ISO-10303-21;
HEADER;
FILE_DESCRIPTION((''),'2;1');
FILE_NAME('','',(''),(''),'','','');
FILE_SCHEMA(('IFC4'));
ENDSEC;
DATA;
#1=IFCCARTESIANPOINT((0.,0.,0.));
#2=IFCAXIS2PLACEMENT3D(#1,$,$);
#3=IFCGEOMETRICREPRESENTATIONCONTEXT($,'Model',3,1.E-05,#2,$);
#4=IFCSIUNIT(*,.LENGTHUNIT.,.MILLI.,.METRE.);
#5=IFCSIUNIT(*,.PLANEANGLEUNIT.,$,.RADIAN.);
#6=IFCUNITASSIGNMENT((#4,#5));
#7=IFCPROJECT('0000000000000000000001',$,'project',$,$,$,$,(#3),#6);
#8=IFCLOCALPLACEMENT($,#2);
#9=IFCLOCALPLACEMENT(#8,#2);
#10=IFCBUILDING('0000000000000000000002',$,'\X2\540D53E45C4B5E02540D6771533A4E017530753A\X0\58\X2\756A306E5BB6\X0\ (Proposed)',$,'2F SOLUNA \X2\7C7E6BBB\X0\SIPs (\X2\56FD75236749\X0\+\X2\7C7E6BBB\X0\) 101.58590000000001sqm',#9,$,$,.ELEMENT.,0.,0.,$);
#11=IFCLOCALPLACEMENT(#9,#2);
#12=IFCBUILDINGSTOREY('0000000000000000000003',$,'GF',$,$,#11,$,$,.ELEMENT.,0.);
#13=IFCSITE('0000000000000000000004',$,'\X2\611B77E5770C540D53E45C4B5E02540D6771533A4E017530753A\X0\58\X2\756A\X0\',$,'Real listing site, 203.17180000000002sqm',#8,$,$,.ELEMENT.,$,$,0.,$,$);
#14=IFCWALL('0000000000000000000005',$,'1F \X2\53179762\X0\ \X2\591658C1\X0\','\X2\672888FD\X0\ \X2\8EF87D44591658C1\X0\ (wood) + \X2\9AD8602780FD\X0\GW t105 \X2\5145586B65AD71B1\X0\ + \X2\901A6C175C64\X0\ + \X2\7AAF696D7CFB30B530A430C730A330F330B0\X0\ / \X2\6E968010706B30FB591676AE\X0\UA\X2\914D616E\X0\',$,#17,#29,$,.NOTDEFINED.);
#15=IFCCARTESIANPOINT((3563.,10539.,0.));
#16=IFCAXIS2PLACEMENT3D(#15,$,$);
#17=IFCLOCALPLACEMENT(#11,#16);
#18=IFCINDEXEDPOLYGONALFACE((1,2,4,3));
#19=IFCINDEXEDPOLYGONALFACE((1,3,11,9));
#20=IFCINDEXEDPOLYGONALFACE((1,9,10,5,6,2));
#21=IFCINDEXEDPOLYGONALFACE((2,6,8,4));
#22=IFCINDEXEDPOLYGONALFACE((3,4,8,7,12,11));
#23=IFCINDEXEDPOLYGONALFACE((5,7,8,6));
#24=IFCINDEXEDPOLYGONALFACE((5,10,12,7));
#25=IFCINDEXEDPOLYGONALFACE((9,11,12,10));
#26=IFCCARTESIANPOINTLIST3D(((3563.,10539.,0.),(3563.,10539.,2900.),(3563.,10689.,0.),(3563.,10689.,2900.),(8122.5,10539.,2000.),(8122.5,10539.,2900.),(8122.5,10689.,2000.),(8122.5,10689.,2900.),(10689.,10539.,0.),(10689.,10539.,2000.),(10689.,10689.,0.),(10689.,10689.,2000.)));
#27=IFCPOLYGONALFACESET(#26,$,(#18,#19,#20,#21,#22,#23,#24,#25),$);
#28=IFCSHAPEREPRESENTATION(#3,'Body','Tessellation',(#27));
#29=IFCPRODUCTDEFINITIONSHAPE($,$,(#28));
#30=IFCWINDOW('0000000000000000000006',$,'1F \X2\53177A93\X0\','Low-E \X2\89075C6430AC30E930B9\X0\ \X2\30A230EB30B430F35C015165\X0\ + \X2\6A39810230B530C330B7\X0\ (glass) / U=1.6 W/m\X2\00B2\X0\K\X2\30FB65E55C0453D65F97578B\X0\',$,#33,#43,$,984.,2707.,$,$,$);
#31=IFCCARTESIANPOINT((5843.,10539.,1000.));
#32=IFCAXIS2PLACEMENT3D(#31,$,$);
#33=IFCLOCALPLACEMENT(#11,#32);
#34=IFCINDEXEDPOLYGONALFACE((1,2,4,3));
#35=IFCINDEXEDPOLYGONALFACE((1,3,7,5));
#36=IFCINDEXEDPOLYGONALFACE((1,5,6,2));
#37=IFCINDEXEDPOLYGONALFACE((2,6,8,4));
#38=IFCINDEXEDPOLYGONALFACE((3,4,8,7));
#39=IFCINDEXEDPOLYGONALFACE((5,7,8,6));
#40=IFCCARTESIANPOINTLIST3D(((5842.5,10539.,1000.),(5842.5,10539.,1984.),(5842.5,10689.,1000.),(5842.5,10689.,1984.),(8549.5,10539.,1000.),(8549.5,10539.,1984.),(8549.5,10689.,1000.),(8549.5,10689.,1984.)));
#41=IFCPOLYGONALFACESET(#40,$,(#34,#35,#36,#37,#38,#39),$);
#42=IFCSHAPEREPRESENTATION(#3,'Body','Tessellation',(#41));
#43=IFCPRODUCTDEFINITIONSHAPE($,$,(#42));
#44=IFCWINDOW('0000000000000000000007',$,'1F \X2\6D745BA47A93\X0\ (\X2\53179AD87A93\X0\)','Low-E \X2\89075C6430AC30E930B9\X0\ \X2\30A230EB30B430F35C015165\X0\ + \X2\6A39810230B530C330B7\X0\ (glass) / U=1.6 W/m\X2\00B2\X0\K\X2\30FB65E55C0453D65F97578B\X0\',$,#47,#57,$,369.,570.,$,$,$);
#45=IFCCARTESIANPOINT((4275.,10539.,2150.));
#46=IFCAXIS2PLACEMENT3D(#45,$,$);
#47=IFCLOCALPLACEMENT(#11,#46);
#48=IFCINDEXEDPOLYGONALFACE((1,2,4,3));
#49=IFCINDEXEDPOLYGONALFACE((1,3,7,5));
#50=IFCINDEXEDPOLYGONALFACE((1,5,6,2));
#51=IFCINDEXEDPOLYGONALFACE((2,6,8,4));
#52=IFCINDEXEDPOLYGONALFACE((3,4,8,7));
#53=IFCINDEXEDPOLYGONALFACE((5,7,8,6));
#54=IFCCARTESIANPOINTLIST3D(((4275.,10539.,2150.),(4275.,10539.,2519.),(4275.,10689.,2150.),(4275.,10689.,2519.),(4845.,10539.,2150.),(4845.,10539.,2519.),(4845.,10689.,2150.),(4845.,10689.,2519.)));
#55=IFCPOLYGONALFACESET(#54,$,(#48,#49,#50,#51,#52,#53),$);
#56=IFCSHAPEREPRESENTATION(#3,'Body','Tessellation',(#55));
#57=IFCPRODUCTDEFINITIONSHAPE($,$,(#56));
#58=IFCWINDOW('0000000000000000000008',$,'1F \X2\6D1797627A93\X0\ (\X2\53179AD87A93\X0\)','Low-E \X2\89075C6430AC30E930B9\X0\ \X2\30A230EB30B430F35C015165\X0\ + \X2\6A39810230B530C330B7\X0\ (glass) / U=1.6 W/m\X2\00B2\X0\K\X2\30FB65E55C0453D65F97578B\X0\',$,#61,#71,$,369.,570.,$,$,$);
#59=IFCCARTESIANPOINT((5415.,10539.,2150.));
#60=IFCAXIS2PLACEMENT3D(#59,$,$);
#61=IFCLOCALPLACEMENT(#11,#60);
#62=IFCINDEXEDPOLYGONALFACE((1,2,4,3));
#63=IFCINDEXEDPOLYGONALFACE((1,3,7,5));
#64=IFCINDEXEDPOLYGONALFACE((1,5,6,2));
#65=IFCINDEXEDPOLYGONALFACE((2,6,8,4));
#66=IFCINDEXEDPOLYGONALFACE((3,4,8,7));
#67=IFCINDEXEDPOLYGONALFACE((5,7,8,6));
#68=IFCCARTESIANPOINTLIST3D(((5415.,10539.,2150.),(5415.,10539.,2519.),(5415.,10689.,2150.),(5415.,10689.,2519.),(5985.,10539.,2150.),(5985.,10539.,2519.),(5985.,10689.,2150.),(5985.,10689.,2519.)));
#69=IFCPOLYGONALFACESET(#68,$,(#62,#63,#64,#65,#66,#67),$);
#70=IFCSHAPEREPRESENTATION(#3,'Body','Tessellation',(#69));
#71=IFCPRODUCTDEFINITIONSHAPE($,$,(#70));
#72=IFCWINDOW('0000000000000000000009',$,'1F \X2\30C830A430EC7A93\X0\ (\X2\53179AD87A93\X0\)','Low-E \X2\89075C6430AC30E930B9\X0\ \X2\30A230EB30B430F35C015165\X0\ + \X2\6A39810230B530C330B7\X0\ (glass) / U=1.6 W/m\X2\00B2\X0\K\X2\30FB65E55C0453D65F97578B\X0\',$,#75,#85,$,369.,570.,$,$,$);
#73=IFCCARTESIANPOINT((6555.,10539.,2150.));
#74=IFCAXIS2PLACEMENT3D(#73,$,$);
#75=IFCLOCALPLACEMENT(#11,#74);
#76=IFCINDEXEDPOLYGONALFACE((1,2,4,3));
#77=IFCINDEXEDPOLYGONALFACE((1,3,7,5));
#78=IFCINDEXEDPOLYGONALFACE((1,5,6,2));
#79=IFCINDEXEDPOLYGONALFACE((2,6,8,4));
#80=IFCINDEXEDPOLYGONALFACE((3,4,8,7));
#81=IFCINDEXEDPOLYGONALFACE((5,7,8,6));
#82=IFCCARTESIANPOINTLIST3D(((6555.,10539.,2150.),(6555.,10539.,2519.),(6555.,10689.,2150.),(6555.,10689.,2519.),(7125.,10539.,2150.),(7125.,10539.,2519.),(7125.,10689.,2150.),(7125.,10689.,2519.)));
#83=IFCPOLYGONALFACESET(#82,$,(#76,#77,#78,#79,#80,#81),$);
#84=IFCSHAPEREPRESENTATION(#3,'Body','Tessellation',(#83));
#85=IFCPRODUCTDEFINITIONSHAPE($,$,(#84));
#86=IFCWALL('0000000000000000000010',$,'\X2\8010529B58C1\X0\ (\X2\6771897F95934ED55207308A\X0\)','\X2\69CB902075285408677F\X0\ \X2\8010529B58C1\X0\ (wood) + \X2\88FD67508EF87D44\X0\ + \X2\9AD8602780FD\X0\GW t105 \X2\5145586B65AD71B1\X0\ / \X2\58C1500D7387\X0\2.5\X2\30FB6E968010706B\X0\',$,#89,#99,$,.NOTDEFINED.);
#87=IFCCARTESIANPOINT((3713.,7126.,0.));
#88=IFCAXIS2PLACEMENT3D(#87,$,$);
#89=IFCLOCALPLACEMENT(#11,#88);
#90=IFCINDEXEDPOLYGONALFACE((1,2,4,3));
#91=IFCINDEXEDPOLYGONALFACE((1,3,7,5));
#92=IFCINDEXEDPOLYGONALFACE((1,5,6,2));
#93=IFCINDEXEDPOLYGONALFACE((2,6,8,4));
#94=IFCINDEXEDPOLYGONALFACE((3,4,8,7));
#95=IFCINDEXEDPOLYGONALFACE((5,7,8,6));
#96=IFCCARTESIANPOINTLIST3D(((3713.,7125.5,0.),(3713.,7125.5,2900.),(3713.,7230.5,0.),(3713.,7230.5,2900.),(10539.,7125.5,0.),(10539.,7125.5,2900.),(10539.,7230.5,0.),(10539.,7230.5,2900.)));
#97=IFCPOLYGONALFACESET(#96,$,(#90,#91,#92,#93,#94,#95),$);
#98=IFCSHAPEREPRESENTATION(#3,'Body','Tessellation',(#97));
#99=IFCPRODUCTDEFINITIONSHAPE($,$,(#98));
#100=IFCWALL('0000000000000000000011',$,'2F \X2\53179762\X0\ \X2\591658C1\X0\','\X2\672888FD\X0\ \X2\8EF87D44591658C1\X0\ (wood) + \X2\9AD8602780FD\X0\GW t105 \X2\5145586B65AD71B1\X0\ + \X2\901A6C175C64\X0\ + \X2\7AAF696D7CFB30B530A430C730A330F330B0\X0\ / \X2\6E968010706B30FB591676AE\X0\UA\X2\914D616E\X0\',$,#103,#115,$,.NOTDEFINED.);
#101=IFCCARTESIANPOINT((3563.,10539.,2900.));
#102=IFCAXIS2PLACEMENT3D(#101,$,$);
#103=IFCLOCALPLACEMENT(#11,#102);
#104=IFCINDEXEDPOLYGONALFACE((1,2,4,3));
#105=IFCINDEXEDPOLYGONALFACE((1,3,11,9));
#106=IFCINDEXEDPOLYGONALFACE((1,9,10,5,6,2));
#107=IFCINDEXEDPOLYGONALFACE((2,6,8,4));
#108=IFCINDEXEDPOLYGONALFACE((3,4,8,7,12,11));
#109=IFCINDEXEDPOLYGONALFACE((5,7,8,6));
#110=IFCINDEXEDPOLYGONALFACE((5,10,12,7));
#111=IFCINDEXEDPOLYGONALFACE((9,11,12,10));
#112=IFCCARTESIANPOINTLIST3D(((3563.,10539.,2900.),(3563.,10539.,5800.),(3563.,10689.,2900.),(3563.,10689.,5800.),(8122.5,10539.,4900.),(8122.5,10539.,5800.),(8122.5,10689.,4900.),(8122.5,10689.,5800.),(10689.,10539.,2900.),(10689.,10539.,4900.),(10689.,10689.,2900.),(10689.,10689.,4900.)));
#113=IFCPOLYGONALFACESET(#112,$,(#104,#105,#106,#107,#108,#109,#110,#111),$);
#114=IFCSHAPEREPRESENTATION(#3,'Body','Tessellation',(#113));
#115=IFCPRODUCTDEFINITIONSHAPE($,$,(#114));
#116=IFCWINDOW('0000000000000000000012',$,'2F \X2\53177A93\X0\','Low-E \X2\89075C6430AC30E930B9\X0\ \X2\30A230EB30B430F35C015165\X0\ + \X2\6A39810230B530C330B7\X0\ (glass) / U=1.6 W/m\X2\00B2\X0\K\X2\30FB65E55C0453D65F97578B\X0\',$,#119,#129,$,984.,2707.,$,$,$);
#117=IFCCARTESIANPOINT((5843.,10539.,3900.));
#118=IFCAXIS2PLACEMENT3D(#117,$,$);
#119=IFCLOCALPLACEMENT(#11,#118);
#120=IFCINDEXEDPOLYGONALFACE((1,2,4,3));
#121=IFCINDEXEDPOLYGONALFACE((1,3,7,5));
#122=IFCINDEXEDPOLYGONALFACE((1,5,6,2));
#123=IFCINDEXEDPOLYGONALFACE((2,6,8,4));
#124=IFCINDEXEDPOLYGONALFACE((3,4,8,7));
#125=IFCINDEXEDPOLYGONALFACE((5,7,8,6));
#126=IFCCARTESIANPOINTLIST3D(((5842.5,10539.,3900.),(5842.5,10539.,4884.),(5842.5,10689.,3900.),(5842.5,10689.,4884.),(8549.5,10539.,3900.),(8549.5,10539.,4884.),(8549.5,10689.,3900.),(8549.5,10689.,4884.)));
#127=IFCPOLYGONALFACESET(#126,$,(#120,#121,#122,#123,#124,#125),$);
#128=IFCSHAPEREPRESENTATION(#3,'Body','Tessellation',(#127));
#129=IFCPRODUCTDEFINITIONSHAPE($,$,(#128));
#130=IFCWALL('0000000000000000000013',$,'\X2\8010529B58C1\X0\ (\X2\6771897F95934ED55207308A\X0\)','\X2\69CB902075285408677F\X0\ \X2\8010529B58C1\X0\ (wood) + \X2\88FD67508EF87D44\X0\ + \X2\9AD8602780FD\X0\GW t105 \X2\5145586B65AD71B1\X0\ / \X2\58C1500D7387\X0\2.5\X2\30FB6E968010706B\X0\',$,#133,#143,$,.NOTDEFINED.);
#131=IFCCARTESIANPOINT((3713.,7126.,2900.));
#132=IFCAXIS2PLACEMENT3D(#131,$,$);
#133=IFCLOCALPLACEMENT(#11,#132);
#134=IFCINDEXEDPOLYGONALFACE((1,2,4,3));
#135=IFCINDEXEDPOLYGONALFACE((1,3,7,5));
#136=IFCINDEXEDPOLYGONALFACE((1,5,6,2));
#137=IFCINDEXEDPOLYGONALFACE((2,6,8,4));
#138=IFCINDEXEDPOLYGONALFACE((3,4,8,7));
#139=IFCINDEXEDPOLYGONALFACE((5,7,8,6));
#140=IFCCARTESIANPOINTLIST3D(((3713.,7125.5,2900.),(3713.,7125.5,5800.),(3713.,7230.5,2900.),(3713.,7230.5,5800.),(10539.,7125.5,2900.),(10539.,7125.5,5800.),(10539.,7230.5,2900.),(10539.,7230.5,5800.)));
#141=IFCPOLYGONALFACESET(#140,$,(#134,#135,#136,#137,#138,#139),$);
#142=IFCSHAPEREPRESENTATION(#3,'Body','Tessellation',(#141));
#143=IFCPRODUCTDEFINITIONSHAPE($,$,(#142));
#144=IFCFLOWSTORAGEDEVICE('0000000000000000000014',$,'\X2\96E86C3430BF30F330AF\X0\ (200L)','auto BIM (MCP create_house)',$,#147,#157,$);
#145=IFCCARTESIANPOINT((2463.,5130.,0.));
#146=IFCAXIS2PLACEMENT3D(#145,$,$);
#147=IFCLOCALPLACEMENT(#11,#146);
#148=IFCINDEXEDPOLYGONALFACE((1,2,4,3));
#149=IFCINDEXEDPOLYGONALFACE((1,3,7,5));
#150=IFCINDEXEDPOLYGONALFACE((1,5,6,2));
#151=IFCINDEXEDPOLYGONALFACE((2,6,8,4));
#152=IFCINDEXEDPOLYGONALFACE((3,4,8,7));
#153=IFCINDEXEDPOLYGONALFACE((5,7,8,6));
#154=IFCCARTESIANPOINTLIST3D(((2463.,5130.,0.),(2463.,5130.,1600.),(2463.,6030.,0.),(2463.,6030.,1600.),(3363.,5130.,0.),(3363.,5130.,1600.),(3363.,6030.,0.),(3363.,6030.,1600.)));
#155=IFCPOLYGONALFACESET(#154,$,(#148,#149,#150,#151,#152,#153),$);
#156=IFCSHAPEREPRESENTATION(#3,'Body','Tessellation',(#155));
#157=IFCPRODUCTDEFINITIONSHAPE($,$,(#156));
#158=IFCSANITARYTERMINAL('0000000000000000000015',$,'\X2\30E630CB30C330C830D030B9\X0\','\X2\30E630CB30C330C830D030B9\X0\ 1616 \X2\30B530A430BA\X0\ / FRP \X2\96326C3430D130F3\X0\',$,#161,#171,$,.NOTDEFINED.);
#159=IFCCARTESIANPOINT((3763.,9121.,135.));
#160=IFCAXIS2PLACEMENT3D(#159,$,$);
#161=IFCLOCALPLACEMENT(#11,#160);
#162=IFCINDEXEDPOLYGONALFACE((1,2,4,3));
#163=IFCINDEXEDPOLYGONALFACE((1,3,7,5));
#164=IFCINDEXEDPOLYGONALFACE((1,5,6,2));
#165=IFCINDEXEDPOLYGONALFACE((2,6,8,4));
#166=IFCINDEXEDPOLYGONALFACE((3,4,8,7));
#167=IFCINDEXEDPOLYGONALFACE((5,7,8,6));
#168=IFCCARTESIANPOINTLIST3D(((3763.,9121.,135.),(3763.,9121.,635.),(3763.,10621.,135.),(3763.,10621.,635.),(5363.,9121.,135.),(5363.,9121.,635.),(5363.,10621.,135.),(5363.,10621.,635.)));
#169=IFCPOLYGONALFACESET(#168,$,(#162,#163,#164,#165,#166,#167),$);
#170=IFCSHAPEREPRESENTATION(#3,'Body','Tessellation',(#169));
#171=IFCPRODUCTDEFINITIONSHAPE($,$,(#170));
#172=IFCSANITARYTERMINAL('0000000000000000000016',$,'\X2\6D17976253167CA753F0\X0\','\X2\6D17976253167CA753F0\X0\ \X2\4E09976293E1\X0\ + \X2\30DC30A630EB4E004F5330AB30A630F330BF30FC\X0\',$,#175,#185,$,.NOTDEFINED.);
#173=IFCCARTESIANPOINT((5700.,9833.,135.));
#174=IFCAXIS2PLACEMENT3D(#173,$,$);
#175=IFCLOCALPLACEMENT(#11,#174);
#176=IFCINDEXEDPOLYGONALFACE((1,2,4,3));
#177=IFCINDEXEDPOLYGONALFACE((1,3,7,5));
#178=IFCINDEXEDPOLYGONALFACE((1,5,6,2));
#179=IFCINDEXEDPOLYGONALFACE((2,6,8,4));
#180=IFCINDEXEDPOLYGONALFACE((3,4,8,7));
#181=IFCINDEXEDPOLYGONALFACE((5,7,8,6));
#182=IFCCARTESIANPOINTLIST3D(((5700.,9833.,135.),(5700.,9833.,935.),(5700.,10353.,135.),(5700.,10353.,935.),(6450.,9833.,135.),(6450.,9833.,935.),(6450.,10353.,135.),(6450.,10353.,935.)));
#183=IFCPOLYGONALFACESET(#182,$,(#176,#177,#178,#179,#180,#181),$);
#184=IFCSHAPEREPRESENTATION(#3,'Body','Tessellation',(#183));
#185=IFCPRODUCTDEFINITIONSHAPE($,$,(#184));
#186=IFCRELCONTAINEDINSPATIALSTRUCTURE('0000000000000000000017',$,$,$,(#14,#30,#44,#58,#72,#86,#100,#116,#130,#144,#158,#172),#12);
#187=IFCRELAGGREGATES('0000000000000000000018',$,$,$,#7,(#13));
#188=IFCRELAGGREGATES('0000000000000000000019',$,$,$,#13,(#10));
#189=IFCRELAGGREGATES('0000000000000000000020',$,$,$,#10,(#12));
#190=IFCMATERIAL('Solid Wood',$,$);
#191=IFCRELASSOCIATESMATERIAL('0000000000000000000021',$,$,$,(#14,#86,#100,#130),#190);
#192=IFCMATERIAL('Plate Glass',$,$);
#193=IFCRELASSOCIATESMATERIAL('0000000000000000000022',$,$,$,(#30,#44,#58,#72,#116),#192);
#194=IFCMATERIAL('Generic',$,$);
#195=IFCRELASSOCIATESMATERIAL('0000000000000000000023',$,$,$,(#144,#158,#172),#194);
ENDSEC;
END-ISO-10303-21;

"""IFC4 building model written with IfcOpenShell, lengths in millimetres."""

from ifc_helpers import new_model, si_unit, frame, frame_2d, origin, place, context, project, spatial, rectangle, extrude, material, element, fill, save


model = new_model("IFC4")

# Units and contexts
model_context = context("Model", 3, precision=1e-05, world=origin())
ifc_project = project(units=[si_unit("LENGTHUNIT", "METRE", prefix="MILLI"), si_unit("PLANEANGLEUNIT", "RADIAN")], contexts=[model_context])

# Site, building, storey
site_placement = place(None, origin())
site = spatial("IfcSite", under=ifc_project, at=site_placement, Name="愛知県名古屋市名東区丁田町58番", ObjectType="Real listing site, 203.17180000000002sqm", CompositionType="ELEMENT", RefElevation=0.0)
building_placement = place(site_placement, origin())
building = spatial("IfcBuilding", under=site, at=building_placement, Name="名古屋市名東区丁田町58番の家 (Proposed)", ObjectType="2F SOLUNA 籾殻SIPs (国産杉+籾殻) 101.58590000000001sqm", CompositionType="ELEMENT", ElevationOfRefHeight=0.0, ElevationOfTerrain=0.0)
storey_placement = place(building_placement, origin())
storey = spatial("IfcBuildingStorey", under=building, at=storey_placement, Name="GF", CompositionType="ELEMENT", Elevation=0.0)

# Wall, openings, windows
ifc_material_1 = material(Name="Solid Wood")
wall_1_placement = place(storey_placement, frame((3563.0, 10539.0, 0.0)))
wall_1 = element("IfcWall", 1, at=wall_1_placement, inside=storey, material=ifc_material_1, Name="1F 北面 外壁", Description="木製 軸組外壁 (wood) + 高性能GW t105 充填断熱 + 通気層 + 窯業系サイディング / 準耐火・外皮UA配慮", PredefinedType="NOTDEFINED", context=model_context, shape_type="SweptSolid", body=[
    extrude(rectangle(XDim=7126.0, YDim=150.0, at=frame_2d((3563.0, 75.0))), frame((3563.0, 10539.0, 0.0)), (0.0, 0.0, 1.0), 2900.0),
])
opening_1_placement = place(storey_placement, frame((5843.0, 10539.0, 1000.0)))
opening_1 = element("IfcOpeningElement", 2, at=opening_1_placement, cuts=wall_1, PredefinedType="NOTDEFINED", context=model_context, shape_type="SweptSolid", body=[
    extrude(rectangle(XDim=2707.0, YDim=150.0, at=frame_2d((1353.0, 75.0))), frame((5843.0, 10539.0, 1000.0)), (0.0, 0.0, 1.0), 984.0),
])
opening_2_placement = place(storey_placement, frame((4275.0, 10539.0, 2150.0)))
opening_2 = element("IfcOpeningElement", 3, at=opening_2_placement, cuts=wall_1, PredefinedType="NOTDEFINED", context=model_context, shape_type="SweptSolid", body=[
    extrude(rectangle(XDim=570.0, YDim=150.0, at=frame_2d((285.0, 75.0))), frame((4275.0, 10539.0, 2150.0)), (0.0, 0.0, 1.0), 369.0),
])
opening_3_placement = place(storey_placement, frame((5415.0, 10539.0, 2150.0)))
opening_3 = element("IfcOpeningElement", 4, at=opening_3_placement, cuts=wall_1, PredefinedType="NOTDEFINED", context=model_context, shape_type="SweptSolid", body=[
    extrude(rectangle(XDim=570.0, YDim=150.0, at=frame_2d((285.0, 75.0))), frame((5415.0, 10539.0, 2150.0)), (0.0, 0.0, 1.0), 369.0),
])
opening_4_placement = place(storey_placement, frame((6555.0, 10539.0, 2150.0)))
opening_4 = element("IfcOpeningElement", 5, at=opening_4_placement, cuts=wall_1, PredefinedType="NOTDEFINED", context=model_context, shape_type="SweptSolid", body=[
    extrude(rectangle(XDim=570.0, YDim=150.0, at=frame_2d((285.0, 75.0))), frame((6555.0, 10539.0, 2150.0)), (0.0, 0.0, 1.0), 369.0),
])
ifc_material_2 = material(Name="Plate Glass")
window_1_placement = place(storey_placement, frame((5843.0, 10539.0, 1000.0)))
window_1 = element("IfcWindow", 6, at=window_1_placement, inside=storey, material=ifc_material_2, Name="1F 北窓", Description="Low-E 複層ガラス アルゴン封入 + 樹脂サッシ (glass) / U=1.6 W/m²K・日射取得型", OverallHeight=984.0, OverallWidth=2707.0, context=model_context, shape_type="SweptSolid", body=[
    extrude(rectangle(XDim=2707.0, YDim=150.0, at=frame_2d((1353.0, 75.0))), frame((5843.0, 10539.0, 1000.0)), (0.0, 0.0, 1.0), 984.0),
])
fill(opening_1, window_1)
window_2_placement = place(storey_placement, frame((4275.0, 10539.0, 2150.0)))
window_2 = element("IfcWindow", 7, at=window_2_placement, inside=storey, material=ifc_material_2, Name="1F 浴室窓 (北高窓)", Description="Low-E 複層ガラス アルゴン封入 + 樹脂サッシ (glass) / U=1.6 W/m²K・日射取得型", OverallHeight=369.0, OverallWidth=570.0, context=model_context, shape_type="SweptSolid", body=[
    extrude(rectangle(XDim=570.0, YDim=150.0, at=frame_2d((285.0, 75.0))), frame((4275.0, 10539.0, 2150.0)), (0.0, 0.0, 1.0), 369.0),
])
fill(opening_2, window_2)
window_3_placement = place(storey_placement, frame((5415.0, 10539.0, 2150.0)))
window_3 = element("IfcWindow", 8, at=window_3_placement, inside=storey, material=ifc_material_2, Name="1F 洗面窓 (北高窓)", Description="Low-E 複層ガラス アルゴン封入 + 樹脂サッシ (glass) / U=1.6 W/m²K・日射取得型", OverallHeight=369.0, OverallWidth=570.0, context=model_context, shape_type="SweptSolid", body=[
    extrude(rectangle(XDim=570.0, YDim=150.0, at=frame_2d((285.0, 75.0))), frame((5415.0, 10539.0, 2150.0)), (0.0, 0.0, 1.0), 369.0),
])
fill(opening_3, window_3)
window_4_placement = place(storey_placement, frame((6555.0, 10539.0, 2150.0)))
window_4 = element("IfcWindow", 9, at=window_4_placement, inside=storey, material=ifc_material_2, Name="1F トイレ窓 (北高窓)", Description="Low-E 複層ガラス アルゴン封入 + 樹脂サッシ (glass) / U=1.6 W/m²K・日射取得型", OverallHeight=369.0, OverallWidth=570.0, context=model_context, shape_type="SweptSolid", body=[
    extrude(rectangle(XDim=570.0, YDim=150.0, at=frame_2d((285.0, 75.0))), frame((6555.0, 10539.0, 2150.0)), (0.0, 0.0, 1.0), 369.0),
])
fill(opening_4, window_4)

# Wall
wall_2_placement = place(storey_placement, frame((3713.0, 7126.0, 0.0)))
element("IfcWall", 10, at=wall_2_placement, inside=storey, material=ifc_material_1, Name="耐力壁 (東西間仕切り)", Description="構造用合板 耐力壁 (wood) + 製材軸組 + 高性能GW t105 充填断熱 / 壁倍率2.5・準耐火", PredefinedType="NOTDEFINED", context=model_context, shape_type="SweptSolid", body=[
    extrude(rectangle(XDim=6826.0, YDim=105.0, at=frame_2d((3413.0, 52.0))), frame((3713.0, 7126.0, 0.0)), (0.0, 0.0, 1.0), 2900.0),
])

# Wall, opening, window
wall_3_placement = place(storey_placement, frame((3563.0, 10539.0, 2900.0)))
wall_3 = element("IfcWall", 11, at=wall_3_placement, inside=storey, material=ifc_material_1, Name="2F 北面 外壁", Description="木製 軸組外壁 (wood) + 高性能GW t105 充填断熱 + 通気層 + 窯業系サイディング / 準耐火・外皮UA配慮", PredefinedType="NOTDEFINED", context=model_context, shape_type="SweptSolid", body=[
    extrude(rectangle(XDim=7126.0, YDim=150.0, at=frame_2d((3563.0, 75.0))), frame((3563.0, 10539.0, 2900.0)), (0.0, 0.0, 1.0), 2900.0),
])
opening_5_placement = place(storey_placement, frame((5843.0, 10539.0, 3900.0)))
opening_5 = element("IfcOpeningElement", 12, at=opening_5_placement, cuts=wall_3, PredefinedType="NOTDEFINED", context=model_context, shape_type="SweptSolid", body=[
    extrude(rectangle(XDim=2707.0, YDim=150.0, at=frame_2d((1353.0, 75.0))), frame((5843.0, 10539.0, 3900.0)), (0.0, 0.0, 1.0), 984.0),
])
window_5_placement = place(storey_placement, frame((5843.0, 10539.0, 3900.0)))
window_5 = element("IfcWindow", 13, at=window_5_placement, inside=storey, material=ifc_material_2, Name="2F 北窓", Description="Low-E 複層ガラス アルゴン封入 + 樹脂サッシ (glass) / U=1.6 W/m²K・日射取得型", OverallHeight=984.0, OverallWidth=2707.0, context=model_context, shape_type="SweptSolid", body=[
    extrude(rectangle(XDim=2707.0, YDim=150.0, at=frame_2d((1353.0, 75.0))), frame((5843.0, 10539.0, 3900.0)), (0.0, 0.0, 1.0), 984.0),
])
fill(opening_5, window_5)

# Wall
wall_4_placement = place(storey_placement, frame((3713.0, 7126.0, 2900.0)))
element("IfcWall", 14, at=wall_4_placement, inside=storey, material=ifc_material_1, Name="耐力壁 (東西間仕切り)", Description="構造用合板 耐力壁 (wood) + 製材軸組 + 高性能GW t105 充填断熱 / 壁倍率2.5・準耐火", PredefinedType="NOTDEFINED", context=model_context, shape_type="SweptSolid", body=[
    extrude(rectangle(XDim=6826.0, YDim=105.0, at=frame_2d((3413.0, 52.0))), frame((3713.0, 7126.0, 2900.0)), (0.0, 0.0, 1.0), 2900.0),
])

# Flow storage device
ifc_material_3 = material(Name="Generic")
flow_storage_device_placement = place(storey_placement, frame((2463.0, 5130.0, 0.0)))
element("IfcFlowStorageDevice", 15, at=flow_storage_device_placement, inside=storey, material=ifc_material_3, Name="雨水タンク (200L)", Description="auto BIM (MCP create_house)", context=model_context, shape_type="SweptSolid", body=[
    extrude(rectangle(XDim=900.0, YDim=900.0, at=frame_2d((450.0, 450.0))), frame((2463.0, 5130.0, 0.0)), (0.0, 0.0, 1.0), 1600.0),
])

# Sanitary terminals
sanitary_terminal_1_placement = place(storey_placement, frame((3763.0, 9121.0, 135.0)))
element("IfcSanitaryTerminal", 16, at=sanitary_terminal_1_placement, inside=storey, material=ifc_material_3, Name="ユニットバス", Description="ユニットバス 1616 サイズ / FRP 防水パン", PredefinedType="NOTDEFINED", context=model_context, shape_type="SweptSolid", body=[
    extrude(rectangle(XDim=1600.0, YDim=1500.0, at=frame_2d((800.0, 750.0))), frame((3763.0, 9121.0, 135.0)), (0.0, 0.0, 1.0), 500.0),
])
sanitary_terminal_2_placement = place(storey_placement, frame((5700.0, 9833.0, 135.0)))
element("IfcSanitaryTerminal", 17, at=sanitary_terminal_2_placement, inside=storey, material=ifc_material_3, Name="洗面化粧台", Description="洗面化粧台 三面鏡 + ボウル一体カウンター", PredefinedType="NOTDEFINED", context=model_context, shape_type="SweptSolid", body=[
    extrude(rectangle(XDim=750.0, YDim=520.0, at=frame_2d((375.0, 260.0))), frame((5700.0, 9833.0, 135.0)), (0.0, 0.0, 1.0), 800.0),
])

save(model, "model.ifc")
